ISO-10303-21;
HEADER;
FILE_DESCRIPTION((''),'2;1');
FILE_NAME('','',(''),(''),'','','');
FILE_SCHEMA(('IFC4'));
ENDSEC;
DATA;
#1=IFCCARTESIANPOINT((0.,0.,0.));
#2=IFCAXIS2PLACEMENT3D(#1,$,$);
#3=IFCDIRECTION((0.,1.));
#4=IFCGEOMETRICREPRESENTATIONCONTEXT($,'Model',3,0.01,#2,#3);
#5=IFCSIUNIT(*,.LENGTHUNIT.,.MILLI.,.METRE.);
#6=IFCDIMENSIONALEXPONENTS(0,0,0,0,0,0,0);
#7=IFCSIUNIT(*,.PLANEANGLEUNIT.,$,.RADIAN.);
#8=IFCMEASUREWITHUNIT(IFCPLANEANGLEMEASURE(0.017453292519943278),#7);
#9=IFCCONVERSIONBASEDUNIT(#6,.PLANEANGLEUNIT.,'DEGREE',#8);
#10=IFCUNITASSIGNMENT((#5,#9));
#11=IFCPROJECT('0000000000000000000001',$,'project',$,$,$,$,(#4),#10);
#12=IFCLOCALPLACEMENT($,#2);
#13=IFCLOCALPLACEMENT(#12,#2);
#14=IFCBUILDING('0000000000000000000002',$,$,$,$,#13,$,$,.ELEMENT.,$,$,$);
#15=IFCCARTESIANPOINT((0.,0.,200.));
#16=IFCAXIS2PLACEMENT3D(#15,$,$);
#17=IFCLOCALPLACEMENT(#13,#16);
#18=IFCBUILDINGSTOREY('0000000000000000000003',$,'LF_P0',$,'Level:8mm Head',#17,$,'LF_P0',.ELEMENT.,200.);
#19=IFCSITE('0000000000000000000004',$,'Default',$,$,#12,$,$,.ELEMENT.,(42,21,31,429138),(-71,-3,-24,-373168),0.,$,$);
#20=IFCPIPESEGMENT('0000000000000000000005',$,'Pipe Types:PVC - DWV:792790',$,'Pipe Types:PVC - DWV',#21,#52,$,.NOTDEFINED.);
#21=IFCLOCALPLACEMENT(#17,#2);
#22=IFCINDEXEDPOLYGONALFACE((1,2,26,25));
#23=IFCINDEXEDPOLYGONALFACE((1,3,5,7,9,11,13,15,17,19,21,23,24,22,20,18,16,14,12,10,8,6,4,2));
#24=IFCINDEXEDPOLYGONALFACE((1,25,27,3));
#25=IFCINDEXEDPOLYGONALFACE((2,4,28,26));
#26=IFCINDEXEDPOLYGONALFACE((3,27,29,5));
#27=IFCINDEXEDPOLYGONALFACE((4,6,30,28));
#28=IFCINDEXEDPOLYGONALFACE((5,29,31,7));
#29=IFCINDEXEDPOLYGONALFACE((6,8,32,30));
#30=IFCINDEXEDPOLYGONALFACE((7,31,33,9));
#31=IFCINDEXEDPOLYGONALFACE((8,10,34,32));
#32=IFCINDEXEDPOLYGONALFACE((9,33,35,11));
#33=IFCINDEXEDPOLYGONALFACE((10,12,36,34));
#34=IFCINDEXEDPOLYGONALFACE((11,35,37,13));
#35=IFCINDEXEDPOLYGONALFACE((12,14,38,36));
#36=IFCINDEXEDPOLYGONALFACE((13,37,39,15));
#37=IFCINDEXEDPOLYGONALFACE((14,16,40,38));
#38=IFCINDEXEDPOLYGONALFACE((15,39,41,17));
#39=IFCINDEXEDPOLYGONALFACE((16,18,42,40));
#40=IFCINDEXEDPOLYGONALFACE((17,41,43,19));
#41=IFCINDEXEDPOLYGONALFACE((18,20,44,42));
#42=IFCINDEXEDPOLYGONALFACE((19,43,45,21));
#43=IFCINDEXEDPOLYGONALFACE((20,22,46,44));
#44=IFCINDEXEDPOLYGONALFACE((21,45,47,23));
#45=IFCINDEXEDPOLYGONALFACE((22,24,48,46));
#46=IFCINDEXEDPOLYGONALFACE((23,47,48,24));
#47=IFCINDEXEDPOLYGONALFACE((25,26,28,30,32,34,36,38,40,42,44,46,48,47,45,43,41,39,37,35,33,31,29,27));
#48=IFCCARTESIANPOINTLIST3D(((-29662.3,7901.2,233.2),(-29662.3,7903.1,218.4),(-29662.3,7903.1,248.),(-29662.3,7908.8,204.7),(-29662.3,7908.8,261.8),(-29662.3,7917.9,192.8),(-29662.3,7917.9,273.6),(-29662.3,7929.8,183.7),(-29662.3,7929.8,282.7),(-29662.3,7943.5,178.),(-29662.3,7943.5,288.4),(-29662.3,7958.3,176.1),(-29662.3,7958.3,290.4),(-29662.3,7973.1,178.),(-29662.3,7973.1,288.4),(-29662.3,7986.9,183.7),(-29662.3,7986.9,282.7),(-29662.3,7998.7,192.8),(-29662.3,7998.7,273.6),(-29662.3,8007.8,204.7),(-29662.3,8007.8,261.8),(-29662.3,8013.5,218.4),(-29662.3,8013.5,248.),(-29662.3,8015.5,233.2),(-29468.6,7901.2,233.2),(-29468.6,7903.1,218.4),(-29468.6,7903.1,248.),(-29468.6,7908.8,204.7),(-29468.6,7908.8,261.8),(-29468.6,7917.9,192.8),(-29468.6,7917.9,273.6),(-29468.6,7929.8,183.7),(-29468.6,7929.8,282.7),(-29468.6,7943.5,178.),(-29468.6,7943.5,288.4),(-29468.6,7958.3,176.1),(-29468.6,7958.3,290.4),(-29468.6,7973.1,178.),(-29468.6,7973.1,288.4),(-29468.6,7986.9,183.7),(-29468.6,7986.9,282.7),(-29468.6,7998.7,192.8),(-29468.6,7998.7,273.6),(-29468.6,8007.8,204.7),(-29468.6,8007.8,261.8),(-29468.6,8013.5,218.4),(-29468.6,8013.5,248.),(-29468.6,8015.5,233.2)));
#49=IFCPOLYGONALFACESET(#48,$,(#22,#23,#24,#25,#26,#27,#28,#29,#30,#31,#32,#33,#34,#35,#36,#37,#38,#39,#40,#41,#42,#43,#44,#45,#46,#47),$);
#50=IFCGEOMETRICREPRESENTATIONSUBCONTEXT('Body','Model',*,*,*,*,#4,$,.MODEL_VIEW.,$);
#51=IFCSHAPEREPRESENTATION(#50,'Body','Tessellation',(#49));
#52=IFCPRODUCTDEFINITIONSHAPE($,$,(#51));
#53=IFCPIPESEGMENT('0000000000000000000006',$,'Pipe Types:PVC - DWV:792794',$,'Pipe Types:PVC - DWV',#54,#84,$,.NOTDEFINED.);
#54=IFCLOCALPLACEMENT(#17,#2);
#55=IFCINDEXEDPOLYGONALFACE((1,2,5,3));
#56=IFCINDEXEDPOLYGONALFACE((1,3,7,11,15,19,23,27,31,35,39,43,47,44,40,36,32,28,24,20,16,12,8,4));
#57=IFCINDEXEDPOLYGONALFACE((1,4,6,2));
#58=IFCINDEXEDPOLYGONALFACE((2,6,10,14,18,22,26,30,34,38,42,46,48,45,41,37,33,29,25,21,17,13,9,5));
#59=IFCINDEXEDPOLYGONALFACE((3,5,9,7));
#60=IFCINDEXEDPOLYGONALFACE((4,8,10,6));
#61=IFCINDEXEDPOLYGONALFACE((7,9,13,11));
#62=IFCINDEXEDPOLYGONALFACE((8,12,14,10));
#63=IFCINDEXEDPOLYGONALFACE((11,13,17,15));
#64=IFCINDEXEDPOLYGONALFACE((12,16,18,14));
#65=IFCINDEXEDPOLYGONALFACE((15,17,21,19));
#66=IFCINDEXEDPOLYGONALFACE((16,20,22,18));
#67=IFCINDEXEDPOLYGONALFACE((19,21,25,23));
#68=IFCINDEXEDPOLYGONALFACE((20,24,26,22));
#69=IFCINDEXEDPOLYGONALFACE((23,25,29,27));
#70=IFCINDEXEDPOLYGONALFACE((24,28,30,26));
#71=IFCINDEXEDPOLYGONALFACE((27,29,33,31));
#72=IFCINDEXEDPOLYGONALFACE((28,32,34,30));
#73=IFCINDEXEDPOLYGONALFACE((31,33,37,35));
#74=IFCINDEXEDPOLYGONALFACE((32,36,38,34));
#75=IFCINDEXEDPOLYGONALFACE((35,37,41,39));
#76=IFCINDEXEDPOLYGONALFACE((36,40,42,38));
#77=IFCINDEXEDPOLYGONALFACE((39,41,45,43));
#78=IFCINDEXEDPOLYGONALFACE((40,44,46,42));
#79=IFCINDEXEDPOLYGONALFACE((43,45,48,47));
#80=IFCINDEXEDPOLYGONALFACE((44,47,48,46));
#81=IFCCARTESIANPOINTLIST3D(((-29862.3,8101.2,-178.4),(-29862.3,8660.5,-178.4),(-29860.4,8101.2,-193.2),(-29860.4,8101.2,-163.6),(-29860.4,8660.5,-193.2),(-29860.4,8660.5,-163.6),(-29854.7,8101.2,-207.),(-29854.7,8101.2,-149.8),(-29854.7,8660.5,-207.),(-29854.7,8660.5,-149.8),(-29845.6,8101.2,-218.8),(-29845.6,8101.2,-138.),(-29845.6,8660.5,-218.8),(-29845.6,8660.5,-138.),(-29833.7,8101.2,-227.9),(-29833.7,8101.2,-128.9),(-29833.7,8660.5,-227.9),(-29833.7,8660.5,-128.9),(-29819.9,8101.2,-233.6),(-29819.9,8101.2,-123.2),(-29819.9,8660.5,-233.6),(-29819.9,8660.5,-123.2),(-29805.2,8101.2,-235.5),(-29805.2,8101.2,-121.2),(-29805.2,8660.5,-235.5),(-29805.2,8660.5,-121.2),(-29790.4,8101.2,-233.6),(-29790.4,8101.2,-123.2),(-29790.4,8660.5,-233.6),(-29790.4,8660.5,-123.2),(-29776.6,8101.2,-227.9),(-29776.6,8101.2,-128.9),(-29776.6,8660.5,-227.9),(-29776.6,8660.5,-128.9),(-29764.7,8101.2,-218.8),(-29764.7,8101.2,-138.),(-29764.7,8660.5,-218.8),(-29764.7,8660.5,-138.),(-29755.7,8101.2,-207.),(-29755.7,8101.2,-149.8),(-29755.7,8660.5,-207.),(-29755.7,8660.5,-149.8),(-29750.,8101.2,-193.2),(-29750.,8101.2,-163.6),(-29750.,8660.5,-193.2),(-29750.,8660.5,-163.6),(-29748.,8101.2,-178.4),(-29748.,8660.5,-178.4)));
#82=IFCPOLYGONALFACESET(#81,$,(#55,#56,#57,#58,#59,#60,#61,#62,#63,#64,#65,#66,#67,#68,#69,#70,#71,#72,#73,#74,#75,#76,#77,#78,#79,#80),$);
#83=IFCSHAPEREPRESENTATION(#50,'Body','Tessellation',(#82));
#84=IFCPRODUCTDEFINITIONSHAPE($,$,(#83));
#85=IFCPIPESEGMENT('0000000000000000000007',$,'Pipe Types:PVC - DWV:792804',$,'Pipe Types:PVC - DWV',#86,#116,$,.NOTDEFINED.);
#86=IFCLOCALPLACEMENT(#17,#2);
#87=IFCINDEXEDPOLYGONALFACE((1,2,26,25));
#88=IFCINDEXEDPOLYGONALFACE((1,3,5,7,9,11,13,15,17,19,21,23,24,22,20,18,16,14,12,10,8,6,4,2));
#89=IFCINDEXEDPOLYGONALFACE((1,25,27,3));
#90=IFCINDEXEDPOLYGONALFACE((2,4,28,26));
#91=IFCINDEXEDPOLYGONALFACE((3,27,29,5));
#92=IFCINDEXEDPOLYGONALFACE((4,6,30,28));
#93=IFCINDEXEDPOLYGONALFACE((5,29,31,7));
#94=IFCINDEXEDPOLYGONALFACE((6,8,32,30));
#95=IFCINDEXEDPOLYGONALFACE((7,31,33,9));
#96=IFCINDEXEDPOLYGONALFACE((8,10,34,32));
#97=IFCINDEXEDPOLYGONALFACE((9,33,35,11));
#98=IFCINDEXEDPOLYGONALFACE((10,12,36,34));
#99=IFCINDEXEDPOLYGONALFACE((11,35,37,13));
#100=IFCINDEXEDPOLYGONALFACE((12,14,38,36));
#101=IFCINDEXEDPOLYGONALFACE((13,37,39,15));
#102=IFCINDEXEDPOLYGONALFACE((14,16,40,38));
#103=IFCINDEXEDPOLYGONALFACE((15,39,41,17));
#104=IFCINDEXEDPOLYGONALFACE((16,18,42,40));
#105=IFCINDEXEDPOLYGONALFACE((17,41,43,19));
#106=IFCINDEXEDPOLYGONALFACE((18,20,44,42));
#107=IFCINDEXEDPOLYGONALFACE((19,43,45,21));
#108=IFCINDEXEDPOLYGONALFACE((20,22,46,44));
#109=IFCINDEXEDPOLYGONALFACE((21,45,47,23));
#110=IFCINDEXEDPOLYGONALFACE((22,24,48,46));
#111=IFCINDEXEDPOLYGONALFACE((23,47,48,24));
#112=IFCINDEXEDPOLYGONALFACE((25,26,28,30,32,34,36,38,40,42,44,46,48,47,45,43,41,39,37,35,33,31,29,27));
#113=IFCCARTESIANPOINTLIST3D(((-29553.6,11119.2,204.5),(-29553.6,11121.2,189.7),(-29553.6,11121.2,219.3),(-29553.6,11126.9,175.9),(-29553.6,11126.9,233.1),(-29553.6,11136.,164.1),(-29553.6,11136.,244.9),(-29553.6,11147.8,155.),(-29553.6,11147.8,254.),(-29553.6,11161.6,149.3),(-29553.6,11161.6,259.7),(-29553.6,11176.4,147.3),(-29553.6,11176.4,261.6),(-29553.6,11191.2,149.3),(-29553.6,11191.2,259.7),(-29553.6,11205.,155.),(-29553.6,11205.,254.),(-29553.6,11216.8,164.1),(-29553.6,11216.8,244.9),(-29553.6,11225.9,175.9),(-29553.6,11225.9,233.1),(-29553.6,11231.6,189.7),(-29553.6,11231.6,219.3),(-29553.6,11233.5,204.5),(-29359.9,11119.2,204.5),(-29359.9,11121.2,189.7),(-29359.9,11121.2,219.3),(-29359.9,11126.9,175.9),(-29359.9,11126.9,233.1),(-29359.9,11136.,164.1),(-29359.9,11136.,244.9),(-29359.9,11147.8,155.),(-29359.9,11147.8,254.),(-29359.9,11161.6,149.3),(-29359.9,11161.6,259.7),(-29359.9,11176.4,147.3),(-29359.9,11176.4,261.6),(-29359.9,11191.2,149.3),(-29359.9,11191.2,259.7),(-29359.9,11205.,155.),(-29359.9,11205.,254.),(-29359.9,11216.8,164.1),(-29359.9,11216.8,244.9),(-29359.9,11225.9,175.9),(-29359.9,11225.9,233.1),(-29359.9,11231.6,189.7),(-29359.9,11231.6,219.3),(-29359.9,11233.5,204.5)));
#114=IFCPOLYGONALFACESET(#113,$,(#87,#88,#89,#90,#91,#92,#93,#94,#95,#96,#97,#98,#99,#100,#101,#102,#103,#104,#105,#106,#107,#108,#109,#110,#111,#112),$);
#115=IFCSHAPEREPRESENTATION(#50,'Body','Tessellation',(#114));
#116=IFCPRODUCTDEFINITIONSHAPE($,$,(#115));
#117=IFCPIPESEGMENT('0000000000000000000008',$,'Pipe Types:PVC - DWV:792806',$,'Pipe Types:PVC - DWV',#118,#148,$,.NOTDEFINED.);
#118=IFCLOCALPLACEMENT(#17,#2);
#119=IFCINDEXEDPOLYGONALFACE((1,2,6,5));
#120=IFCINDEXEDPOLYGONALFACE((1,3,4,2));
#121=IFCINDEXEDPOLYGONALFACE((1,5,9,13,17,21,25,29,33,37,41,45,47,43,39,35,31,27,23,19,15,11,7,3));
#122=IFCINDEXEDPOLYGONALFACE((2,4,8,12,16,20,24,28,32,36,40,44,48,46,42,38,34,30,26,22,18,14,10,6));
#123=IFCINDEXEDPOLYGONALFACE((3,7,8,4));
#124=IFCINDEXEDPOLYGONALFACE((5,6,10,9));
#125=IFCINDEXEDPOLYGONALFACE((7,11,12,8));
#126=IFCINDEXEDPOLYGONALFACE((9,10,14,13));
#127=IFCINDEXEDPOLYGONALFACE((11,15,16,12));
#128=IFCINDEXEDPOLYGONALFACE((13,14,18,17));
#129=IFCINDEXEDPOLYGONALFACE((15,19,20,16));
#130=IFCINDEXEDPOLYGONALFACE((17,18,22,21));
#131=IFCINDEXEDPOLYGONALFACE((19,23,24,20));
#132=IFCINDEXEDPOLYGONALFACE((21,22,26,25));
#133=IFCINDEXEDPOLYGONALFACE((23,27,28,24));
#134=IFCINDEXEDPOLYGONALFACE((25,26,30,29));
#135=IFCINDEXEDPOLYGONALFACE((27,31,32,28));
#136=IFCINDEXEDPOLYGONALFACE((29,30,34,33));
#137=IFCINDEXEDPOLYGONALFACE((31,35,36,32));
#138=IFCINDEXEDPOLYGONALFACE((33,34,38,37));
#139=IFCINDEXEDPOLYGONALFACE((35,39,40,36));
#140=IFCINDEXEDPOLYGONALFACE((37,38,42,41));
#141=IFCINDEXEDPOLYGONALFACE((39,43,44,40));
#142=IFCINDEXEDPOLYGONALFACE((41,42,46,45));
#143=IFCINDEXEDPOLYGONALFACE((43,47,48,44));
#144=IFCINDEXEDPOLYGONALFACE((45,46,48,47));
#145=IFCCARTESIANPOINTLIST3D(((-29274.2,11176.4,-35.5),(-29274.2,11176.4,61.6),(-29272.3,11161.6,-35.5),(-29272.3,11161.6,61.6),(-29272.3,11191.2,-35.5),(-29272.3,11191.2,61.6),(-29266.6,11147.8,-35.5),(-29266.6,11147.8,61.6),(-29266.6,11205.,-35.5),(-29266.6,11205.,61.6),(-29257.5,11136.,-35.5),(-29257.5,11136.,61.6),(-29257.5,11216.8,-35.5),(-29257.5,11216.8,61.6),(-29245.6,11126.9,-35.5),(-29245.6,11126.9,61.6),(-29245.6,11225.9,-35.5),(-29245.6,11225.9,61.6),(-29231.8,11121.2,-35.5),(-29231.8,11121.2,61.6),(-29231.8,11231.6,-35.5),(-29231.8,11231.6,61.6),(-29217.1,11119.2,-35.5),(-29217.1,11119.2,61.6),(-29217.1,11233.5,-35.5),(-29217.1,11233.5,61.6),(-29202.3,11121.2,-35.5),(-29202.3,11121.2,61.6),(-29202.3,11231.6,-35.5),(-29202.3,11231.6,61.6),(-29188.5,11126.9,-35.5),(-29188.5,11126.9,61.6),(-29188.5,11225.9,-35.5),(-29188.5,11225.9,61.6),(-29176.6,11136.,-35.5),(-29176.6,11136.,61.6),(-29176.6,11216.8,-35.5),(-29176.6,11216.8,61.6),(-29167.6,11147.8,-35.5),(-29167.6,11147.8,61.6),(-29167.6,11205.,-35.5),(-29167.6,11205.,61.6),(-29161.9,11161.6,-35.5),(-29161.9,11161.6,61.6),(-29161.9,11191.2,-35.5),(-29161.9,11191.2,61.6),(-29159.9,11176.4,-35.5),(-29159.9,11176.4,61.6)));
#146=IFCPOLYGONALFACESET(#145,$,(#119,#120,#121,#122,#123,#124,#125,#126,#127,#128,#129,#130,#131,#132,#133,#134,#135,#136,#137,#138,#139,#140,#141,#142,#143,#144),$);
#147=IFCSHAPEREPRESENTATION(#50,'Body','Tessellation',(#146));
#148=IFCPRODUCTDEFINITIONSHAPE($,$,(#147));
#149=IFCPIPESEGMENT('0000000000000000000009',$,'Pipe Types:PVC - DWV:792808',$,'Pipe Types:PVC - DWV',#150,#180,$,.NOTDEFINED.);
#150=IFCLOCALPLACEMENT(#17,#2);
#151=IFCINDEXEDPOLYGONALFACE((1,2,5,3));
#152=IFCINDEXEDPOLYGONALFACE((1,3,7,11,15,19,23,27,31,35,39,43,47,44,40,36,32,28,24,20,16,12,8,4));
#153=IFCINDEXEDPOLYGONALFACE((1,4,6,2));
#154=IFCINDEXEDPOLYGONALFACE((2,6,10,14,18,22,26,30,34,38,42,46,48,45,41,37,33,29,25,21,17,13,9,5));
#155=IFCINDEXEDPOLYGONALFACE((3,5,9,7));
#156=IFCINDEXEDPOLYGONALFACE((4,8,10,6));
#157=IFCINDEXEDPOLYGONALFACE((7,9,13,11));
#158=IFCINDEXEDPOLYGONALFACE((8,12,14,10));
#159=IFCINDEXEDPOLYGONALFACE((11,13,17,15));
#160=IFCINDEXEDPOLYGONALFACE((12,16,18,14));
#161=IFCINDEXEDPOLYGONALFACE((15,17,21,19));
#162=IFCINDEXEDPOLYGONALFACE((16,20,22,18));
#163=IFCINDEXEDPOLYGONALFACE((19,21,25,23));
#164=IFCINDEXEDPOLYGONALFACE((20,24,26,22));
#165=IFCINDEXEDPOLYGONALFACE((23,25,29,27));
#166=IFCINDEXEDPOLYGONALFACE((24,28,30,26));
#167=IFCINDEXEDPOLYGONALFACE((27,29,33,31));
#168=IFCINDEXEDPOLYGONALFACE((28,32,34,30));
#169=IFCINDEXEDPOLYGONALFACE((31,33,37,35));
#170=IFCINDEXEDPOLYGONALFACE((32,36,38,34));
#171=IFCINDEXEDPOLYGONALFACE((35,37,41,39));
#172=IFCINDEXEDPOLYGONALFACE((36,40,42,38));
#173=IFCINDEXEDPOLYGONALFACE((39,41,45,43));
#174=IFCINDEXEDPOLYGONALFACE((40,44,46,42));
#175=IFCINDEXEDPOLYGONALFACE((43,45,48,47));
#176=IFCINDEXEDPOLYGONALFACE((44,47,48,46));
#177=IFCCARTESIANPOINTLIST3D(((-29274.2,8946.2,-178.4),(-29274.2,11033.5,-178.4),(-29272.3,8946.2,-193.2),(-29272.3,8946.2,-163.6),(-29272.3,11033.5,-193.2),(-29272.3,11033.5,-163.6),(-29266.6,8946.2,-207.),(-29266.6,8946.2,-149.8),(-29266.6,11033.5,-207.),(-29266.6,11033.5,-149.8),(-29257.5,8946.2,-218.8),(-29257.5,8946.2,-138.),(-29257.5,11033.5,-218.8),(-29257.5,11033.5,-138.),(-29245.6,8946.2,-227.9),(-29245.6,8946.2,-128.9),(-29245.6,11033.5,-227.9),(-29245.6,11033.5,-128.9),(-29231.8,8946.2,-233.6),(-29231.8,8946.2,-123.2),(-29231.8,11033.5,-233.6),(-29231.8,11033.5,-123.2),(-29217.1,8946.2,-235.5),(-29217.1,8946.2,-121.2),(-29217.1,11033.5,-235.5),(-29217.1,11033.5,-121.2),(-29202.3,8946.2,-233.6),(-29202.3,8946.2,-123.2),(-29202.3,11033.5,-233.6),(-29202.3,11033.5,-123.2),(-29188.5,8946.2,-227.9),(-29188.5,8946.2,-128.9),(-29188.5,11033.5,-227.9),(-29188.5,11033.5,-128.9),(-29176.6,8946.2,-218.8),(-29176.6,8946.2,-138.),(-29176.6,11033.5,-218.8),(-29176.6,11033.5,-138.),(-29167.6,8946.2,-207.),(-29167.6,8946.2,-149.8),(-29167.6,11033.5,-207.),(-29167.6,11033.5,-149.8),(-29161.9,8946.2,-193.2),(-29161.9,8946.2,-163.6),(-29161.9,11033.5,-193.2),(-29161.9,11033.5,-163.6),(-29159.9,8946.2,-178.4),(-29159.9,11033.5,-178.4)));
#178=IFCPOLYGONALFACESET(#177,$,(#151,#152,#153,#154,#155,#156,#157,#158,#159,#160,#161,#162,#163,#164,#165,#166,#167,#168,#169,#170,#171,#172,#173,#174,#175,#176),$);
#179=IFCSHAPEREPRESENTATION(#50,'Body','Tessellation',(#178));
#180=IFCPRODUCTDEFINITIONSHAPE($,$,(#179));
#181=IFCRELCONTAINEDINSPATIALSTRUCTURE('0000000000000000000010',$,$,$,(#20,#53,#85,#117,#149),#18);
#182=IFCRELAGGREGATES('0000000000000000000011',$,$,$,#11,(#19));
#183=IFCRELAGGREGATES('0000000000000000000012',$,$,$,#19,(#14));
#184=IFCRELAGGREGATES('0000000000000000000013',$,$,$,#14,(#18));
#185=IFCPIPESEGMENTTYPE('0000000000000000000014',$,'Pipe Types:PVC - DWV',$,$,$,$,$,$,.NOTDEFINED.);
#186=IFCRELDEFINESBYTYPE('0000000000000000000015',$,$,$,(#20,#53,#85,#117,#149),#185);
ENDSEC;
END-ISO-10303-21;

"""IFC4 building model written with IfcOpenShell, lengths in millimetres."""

from ifc_helpers import new_model, entity, si_unit, converted_unit, direction, frame, origin, place, context, subcontext, project, spatial, arc, indexed_curve, outline, extrude, type_object, element, save


model = new_model("IFC4")

# Units and contexts
model_context = context("Model", 3, precision=0.01, world=origin(), true_north=direction((0.0, 1.0)))
body_context = subcontext(model_context, "Body", "Model", "MODEL_VIEW")
ifc_project = project(units=[si_unit("LENGTHUNIT", "METRE", prefix="MILLI"), converted_unit("PLANEANGLEUNIT", "DEGREE", entity("IfcPlaneAngleMeasure", 0.017453292519943278), si_unit("PLANEANGLEUNIT", "RADIAN"), dimensions=[0, 0, 0, 0, 0, 0, 0])], contexts=[model_context])

# Site, building, storey
site_placement = place(None, origin())
site = spatial("IfcSite", under=ifc_project, at=site_placement, Name="Default", CompositionType="ELEMENT", RefLatitude=(42, 21, 31, 429138), RefLongitude=(-71, -3, -24, -373168), RefElevation=0.0)
building_placement = place(site_placement, origin())
building = spatial("IfcBuilding", under=site, at=building_placement, CompositionType="ELEMENT")
storey_placement = place(building_placement, frame((0.0, 0.0, 200.0)))
storey = spatial("IfcBuildingStorey", under=building, at=storey_placement, Name="LF_P0", ObjectType="Level:8mm Head", LongName="LF_P0", CompositionType="ELEMENT", Elevation=200.0)

# Pipe segments
pipe_segment_type_1 = type_object("IfcPipeSegmentType", Name="Pipe Types:PVC - DWV", PredefinedType="NOTDEFINED")
pipe_segment_1_placement = place(storey_placement, origin())
element("IfcPipeSegment", 1, at=pipe_segment_1_placement, inside=storey, type_object=pipe_segment_type_1, Name="Pipe Types:PVC - DWV:792790", ObjectType="Pipe Types:PVC - DWV", PredefinedType="NOTDEFINED", context=body_context, shape_type="SweptSolid", body=[
    extrude(outline(indexed_curve([(57.1, 0.0), (40.4, 40.4), (0.0, 57.2), (-40.4, 40.4), (-57.2, 0.0), (-40.4, -40.4), (0.0, -57.2), (40.4, -40.4)], segments=[arc(1, 2, 3), arc(3, 4, 5), arc(5, 6, 7), arc(7, 8, 1)], self_intersect=False)), frame((-29662.3, 7958.3, 233.2), z_axis=(1.0, 0.0, 0.0), x_axis=(0.0, 1.0, 0.0)), (0.0, 0.0, 1.0), 193.7),
])
pipe_segment_2_placement = place(storey_placement, origin())
element("IfcPipeSegment", 2, at=pipe_segment_2_placement, inside=storey, type_object=pipe_segment_type_1, Name="Pipe Types:PVC - DWV:792794", ObjectType="Pipe Types:PVC - DWV", PredefinedType="NOTDEFINED", context=body_context, shape_type="SweptSolid", body=[
    extrude(outline(indexed_curve([(57.2, 0.0), (40.4, 40.4), (0.0, 57.1), (-40.4, 40.4), (-57.2, 0.0), (-40.4, -40.4), (0.0, -57.2), (40.4, -40.4)], segments=[arc(1, 2, 3), arc(3, 4, 5), arc(5, 6, 7), arc(7, 8, 1)], self_intersect=False)), frame((-29805.2, 8101.2, -178.4), z_axis=(0.0, 1.0, 0.0), x_axis=(1.0, 0.0, 0.0)), (0.0, 0.0, 1.0), 559.3),
])
pipe_segment_3_placement = place(storey_placement, origin())
element("IfcPipeSegment", 3, at=pipe_segment_3_placement, inside=storey, type_object=pipe_segment_type_1, Name="Pipe Types:PVC - DWV:792804", ObjectType="Pipe Types:PVC - DWV", PredefinedType="NOTDEFINED", context=body_context, shape_type="SweptSolid", body=[
    extrude(outline(indexed_curve([(57.2, 0.0), (40.4, 40.4), (0.0, 57.1), (-40.4, 40.4), (-57.2, 0.0), (-40.4, -40.4), (0.0, -57.2), (40.4, -40.4)], segments=[arc(1, 2, 3), arc(3, 4, 5), arc(5, 6, 7), arc(7, 8, 1)], self_intersect=False)), frame((-29553.6, 11176.4, 204.5), z_axis=(1.0, 0.0, 0.0), x_axis=(0.0, -1.0, 0.0)), (0.0, 0.0, 1.0), 193.7),
])
pipe_segment_4_placement = place(storey_placement, origin())
element("IfcPipeSegment", 4, at=pipe_segment_4_placement, inside=storey, type_object=pipe_segment_type_1, Name="Pipe Types:PVC - DWV:792806", ObjectType="Pipe Types:PVC - DWV", PredefinedType="NOTDEFINED", context=body_context, shape_type="SweptSolid", body=[
    extrude(outline(indexed_curve([(57.2, 0.0), (40.4, 40.4), (0.0, 57.2), (-40.4, 40.4), (-57.2, 0.0), (-40.4, -40.4), (0.0, -57.2), (40.4, -40.4)], segments=[arc(1, 2, 3), arc(3, 4, 5), arc(5, 6, 7), arc(7, 8, 1)], self_intersect=False)), frame((-29217.1, 11176.4, -35.5), z_axis=(0.0, 0.0, 1.0), x_axis=(-1.0, 0.0, 0.0)), (0.0, 0.0, 1.0), 97.1),
])
pipe_segment_5_placement = place(storey_placement, origin())
element("IfcPipeSegment", 5, at=pipe_segment_5_placement, inside=storey, type_object=pipe_segment_type_1, Name="Pipe Types:PVC - DWV:792808", ObjectType="Pipe Types:PVC - DWV", PredefinedType="NOTDEFINED", context=body_context, shape_type="SweptSolid", body=[
    extrude(outline(indexed_curve([(57.2, 0.0), (40.4, 40.4), (0.0, 57.1), (-40.4, 40.4), (-57.2, 0.0), (-40.4, -40.4), (0.0, -57.2), (40.4, -40.4)], segments=[arc(1, 2, 3), arc(3, 4, 5), arc(5, 6, 7), arc(7, 8, 1)], self_intersect=False)), frame((-29217.1, 8946.2, -178.4), z_axis=(0.0, 1.0, 0.0), x_axis=(1.0, 0.0, 0.0)), (0.0, 0.0, 1.0), 2087.3),
])

save(model, "model.ifc")
